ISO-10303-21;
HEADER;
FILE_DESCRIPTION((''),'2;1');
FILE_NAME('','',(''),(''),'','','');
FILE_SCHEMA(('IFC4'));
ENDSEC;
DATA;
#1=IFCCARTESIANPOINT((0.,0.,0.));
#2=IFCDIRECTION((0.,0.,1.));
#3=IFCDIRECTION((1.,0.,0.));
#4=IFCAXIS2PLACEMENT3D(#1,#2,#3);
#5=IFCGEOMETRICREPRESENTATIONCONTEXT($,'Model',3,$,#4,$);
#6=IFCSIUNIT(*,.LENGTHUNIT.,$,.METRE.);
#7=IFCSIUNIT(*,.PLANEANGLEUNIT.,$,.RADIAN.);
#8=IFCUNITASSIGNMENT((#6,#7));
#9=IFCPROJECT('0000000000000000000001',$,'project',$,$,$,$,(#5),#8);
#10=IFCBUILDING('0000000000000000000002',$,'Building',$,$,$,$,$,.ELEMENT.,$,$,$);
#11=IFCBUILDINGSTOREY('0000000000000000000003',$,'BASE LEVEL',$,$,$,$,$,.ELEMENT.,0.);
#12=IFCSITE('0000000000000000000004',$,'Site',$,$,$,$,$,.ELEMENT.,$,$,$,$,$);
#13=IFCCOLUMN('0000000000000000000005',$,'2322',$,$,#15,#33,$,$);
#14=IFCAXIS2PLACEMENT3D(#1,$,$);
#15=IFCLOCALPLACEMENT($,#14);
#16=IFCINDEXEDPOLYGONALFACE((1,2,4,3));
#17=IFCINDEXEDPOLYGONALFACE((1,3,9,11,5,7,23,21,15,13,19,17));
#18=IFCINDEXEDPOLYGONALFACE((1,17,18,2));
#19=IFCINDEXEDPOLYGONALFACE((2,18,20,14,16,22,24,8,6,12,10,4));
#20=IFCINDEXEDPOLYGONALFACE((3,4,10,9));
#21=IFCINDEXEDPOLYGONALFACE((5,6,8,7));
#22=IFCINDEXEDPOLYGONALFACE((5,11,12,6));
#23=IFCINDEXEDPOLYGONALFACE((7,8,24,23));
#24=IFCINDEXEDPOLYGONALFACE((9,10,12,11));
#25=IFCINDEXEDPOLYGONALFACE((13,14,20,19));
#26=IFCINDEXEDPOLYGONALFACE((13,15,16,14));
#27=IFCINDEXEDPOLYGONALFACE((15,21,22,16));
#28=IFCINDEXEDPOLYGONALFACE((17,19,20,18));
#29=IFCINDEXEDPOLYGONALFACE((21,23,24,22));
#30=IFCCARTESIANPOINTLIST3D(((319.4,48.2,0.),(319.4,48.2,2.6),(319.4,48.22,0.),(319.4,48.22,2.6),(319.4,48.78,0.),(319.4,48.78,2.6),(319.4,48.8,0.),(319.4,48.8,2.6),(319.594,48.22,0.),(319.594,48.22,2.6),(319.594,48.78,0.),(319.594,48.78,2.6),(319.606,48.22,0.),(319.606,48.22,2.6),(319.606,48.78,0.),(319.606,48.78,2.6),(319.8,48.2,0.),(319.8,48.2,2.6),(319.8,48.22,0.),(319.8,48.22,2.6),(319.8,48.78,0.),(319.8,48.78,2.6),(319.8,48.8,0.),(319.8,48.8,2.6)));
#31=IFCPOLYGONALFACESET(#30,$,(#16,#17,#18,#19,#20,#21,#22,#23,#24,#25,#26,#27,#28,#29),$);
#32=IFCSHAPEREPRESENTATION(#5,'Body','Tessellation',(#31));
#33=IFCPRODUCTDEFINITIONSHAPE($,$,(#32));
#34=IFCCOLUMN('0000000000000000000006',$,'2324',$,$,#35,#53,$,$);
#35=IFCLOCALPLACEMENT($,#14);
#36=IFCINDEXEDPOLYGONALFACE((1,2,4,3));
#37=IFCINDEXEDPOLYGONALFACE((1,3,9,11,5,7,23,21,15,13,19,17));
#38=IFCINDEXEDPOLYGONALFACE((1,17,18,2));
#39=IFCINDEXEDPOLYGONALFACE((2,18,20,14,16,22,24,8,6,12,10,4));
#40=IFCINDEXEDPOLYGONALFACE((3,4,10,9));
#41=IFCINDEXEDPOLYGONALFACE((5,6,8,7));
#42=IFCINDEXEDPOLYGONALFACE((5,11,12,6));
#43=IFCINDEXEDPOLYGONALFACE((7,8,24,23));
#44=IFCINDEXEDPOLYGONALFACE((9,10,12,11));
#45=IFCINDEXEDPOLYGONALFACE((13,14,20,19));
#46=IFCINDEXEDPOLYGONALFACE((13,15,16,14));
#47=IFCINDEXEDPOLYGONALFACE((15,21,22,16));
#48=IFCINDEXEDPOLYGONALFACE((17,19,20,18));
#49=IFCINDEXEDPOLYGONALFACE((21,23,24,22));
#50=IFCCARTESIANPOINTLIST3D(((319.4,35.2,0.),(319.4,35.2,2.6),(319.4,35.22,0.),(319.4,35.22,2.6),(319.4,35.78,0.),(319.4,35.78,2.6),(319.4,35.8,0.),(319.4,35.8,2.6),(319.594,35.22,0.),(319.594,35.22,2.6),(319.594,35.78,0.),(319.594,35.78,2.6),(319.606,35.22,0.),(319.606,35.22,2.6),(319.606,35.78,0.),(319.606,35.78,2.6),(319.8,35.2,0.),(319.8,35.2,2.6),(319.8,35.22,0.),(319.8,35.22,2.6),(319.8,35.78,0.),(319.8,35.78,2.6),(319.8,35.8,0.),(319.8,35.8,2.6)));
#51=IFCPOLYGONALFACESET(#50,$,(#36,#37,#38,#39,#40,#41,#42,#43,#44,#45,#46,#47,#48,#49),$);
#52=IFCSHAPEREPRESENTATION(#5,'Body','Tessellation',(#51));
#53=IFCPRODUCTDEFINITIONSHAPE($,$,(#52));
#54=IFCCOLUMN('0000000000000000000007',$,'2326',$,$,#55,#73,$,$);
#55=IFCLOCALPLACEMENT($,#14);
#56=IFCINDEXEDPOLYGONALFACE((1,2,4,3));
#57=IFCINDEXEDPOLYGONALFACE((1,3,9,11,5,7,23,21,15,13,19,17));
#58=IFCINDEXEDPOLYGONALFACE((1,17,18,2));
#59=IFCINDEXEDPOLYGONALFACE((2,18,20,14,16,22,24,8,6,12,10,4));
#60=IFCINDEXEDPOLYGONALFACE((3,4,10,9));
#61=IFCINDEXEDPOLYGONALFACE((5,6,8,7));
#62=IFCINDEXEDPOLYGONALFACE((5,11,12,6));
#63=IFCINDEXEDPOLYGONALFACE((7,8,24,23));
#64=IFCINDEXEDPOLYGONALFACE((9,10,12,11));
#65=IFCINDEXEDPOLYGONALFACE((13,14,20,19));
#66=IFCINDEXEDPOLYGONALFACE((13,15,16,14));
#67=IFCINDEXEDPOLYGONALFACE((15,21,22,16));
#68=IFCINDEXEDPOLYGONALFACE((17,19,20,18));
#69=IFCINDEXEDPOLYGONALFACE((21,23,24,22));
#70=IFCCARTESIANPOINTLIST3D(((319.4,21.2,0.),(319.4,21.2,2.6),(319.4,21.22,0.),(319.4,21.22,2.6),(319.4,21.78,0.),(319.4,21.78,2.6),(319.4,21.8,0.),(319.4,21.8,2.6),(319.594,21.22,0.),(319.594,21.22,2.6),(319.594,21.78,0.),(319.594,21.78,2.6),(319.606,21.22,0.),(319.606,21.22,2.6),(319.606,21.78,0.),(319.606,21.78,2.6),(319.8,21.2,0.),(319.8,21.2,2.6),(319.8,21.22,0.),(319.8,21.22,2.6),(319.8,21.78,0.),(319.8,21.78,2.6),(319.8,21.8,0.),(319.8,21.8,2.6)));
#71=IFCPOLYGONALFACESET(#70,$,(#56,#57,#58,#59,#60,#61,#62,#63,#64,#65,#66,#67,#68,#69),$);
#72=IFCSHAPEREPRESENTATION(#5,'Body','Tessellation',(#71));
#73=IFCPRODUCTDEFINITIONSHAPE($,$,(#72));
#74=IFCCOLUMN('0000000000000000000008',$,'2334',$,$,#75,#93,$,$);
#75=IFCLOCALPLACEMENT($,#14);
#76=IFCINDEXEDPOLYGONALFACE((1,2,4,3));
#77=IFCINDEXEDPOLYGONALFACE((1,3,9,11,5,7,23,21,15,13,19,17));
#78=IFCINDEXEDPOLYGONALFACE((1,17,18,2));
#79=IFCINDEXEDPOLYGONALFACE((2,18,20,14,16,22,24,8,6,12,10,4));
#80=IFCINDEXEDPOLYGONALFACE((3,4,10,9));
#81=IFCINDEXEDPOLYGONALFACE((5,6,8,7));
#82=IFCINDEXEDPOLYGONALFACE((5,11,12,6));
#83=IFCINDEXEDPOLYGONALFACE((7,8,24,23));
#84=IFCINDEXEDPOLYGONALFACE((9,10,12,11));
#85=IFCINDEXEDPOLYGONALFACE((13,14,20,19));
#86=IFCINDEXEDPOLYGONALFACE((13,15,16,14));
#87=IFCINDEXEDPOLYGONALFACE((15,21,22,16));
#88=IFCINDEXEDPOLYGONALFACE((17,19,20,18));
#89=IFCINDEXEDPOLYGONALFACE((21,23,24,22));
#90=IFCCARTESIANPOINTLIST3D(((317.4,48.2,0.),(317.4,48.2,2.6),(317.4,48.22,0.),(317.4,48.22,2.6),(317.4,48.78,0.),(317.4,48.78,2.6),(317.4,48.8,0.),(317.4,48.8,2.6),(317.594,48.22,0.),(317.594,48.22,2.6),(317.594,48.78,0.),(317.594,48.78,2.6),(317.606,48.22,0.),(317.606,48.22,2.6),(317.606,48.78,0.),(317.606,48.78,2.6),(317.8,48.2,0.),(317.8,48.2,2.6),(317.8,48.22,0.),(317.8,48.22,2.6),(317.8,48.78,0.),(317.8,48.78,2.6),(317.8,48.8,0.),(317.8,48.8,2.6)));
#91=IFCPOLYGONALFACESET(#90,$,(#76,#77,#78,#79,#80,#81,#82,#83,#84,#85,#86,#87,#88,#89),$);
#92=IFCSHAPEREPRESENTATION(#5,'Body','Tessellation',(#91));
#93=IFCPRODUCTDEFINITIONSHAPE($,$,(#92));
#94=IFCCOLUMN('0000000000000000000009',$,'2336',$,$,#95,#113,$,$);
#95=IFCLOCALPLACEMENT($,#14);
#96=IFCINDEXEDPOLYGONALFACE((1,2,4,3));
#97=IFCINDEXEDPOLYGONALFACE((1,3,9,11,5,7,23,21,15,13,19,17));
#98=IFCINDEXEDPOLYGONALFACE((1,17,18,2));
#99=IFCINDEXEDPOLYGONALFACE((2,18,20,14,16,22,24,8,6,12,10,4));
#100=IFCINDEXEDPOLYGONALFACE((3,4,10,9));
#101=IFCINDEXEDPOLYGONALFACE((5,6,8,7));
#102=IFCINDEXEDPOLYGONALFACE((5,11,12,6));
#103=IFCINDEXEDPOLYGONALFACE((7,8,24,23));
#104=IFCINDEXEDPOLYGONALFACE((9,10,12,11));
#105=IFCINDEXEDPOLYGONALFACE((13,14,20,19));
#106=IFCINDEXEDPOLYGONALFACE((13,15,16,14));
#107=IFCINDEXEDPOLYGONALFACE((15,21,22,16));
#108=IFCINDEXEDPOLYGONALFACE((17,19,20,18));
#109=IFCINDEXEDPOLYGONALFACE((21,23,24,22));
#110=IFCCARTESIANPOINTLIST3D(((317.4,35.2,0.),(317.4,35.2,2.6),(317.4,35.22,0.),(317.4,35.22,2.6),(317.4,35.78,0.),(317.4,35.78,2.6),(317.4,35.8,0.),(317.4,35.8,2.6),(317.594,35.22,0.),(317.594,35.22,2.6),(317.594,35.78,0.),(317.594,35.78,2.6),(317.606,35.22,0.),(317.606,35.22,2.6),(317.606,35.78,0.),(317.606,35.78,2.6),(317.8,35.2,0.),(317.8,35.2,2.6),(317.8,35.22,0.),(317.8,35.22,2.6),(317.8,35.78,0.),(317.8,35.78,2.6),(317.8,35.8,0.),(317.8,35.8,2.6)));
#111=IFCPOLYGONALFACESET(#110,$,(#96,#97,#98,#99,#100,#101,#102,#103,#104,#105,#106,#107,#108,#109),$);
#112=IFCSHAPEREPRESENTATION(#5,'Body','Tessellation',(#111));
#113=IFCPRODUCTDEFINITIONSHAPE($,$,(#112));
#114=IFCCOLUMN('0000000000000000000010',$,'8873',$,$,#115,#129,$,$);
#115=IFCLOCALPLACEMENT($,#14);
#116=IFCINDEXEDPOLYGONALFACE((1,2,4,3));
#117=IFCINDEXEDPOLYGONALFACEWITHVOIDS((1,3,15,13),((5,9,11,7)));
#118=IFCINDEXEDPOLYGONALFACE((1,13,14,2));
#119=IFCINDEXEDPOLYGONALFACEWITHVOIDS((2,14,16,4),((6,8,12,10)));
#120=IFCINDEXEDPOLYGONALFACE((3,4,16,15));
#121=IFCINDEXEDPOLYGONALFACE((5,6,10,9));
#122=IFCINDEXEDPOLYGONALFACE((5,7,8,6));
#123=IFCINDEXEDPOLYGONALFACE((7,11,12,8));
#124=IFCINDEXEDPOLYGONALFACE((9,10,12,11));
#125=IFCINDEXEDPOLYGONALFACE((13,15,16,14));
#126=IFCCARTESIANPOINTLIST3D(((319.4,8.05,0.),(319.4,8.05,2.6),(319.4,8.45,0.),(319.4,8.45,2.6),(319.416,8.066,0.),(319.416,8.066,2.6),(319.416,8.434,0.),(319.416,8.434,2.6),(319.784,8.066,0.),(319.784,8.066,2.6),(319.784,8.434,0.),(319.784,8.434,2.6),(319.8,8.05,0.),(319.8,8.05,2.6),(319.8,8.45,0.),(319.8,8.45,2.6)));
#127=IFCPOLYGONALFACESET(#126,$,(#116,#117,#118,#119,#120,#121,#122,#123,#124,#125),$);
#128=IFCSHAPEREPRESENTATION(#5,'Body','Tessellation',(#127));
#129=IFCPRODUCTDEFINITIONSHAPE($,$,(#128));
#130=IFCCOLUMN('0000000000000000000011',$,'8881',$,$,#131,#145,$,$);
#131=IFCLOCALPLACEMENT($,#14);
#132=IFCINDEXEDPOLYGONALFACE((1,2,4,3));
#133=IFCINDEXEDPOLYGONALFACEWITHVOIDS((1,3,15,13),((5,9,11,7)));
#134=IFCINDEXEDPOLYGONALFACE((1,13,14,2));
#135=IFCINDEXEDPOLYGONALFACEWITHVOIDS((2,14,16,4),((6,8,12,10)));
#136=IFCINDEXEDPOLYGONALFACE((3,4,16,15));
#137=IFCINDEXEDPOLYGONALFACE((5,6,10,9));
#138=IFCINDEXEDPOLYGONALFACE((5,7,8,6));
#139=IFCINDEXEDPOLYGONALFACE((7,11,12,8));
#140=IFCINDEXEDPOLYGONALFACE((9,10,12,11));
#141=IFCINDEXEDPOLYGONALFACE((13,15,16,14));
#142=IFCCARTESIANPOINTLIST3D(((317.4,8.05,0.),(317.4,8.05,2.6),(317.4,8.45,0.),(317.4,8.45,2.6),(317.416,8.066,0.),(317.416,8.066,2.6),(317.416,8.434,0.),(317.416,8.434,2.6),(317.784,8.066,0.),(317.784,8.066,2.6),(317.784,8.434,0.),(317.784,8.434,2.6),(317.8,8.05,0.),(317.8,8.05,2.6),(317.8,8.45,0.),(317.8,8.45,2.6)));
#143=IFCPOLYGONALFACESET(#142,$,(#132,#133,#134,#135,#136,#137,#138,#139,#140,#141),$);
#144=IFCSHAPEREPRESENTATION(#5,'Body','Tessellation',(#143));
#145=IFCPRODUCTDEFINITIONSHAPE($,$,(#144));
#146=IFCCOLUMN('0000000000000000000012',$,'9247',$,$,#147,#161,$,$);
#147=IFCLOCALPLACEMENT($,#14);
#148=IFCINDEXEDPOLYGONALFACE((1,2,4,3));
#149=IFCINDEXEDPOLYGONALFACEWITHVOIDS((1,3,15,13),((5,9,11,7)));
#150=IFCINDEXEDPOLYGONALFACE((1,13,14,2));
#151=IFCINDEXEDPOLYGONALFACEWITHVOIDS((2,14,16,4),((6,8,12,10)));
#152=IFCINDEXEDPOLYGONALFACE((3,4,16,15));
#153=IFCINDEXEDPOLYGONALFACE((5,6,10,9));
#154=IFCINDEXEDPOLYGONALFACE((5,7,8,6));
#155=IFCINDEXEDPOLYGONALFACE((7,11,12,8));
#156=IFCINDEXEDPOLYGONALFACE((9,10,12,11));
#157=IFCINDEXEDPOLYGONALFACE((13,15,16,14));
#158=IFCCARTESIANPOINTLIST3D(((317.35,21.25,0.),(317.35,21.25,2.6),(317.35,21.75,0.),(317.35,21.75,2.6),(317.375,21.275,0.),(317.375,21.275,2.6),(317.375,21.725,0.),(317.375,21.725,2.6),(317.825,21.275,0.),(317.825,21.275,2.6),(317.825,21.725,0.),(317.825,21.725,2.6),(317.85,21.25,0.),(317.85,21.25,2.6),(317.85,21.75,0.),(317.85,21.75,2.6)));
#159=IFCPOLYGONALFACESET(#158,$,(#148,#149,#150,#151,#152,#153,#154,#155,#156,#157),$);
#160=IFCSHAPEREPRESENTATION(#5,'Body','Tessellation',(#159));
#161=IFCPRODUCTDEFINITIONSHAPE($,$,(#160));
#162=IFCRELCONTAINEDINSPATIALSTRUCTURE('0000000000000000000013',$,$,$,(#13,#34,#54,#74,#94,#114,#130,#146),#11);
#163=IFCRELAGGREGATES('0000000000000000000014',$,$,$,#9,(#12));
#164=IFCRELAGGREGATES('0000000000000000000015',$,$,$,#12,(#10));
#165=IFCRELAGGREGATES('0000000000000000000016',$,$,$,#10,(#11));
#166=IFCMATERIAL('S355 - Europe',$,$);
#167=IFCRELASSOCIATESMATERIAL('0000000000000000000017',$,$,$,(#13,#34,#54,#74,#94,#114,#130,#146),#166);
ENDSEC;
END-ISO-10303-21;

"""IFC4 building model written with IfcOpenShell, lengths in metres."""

from ifc_helpers import new_model, si_unit, frame, origin_with_axes, origin_2d_with_axis, place, context, project, spatial, hollow_rectangle, i_section, extrude, material, material_profile, profile_set, profile_usage, element, save


model = new_model("IFC4")

# Units and contexts
model_context = context("Model", 3, world=origin_with_axes())
ifc_project = project(units=[si_unit("LENGTHUNIT", "METRE"), si_unit("PLANEANGLEUNIT", "RADIAN")], contexts=[model_context])

# Site, building, storey
site = spatial("IfcSite", under=ifc_project, Name="Site", CompositionType="ELEMENT")
building = spatial("IfcBuilding", under=site, Name="Building", CompositionType="ELEMENT")
storey = spatial("IfcBuildingStorey", under=building, Name="BASE LEVEL", CompositionType="ELEMENT", Elevation=0.0)

# Columns
ifc_material = material(Name="S355 - Europe")
ifc_material_profile_1 = material_profile(ifc_material, i_section(OverallWidth=0.4, OverallDepth=0.6, WebThickness=0.012, FlangeThickness=0.02, at=origin_2d_with_axis()))
ifc_profile_set_1 = profile_set([ifc_material_profile_1])
ifc_profile_usage_1 = profile_usage(ifc_profile_set_1, cardinal=10)
column_1_placement = place(None, frame((319.6, 48.5, 0.0), z_axis=(0.0, 0.0, 1.0), x_axis=(1.0, 0.0, 0.0)))
element("IfcColumn", 1, at=column_1_placement, inside=storey, material=ifc_profile_usage_1, Name="2322", context=model_context, shape_type="SweptSolid", body=[
    extrude(i_section(OverallWidth=0.4, OverallDepth=0.6, WebThickness=0.012, FlangeThickness=0.02, at=origin_2d_with_axis()), origin_with_axes(), (0.0, 0.0, 1.0), 2.6),
])
ifc_material_profile_2 = material_profile(ifc_material, i_section(OverallWidth=0.4, OverallDepth=0.6, WebThickness=0.012, FlangeThickness=0.02, at=origin_2d_with_axis()))
ifc_profile_set_2 = profile_set([ifc_material_profile_2])
ifc_profile_usage_2 = profile_usage(ifc_profile_set_2, cardinal=10)
column_2_placement = place(None, frame((319.6, 35.5, 0.0), z_axis=(0.0, 0.0, 1.0), x_axis=(1.0, 0.0, 0.0)))
element("IfcColumn", 2, at=column_2_placement, inside=storey, material=ifc_profile_usage_2, Name="2324", context=model_context, shape_type="SweptSolid", body=[
    extrude(i_section(OverallWidth=0.4, OverallDepth=0.6, WebThickness=0.012, FlangeThickness=0.02, at=origin_2d_with_axis()), origin_with_axes(), (0.0, 0.0, 1.0), 2.6),
])
ifc_material_profile_3 = material_profile(ifc_material, i_section(OverallWidth=0.4, OverallDepth=0.6, WebThickness=0.012, FlangeThickness=0.02, at=origin_2d_with_axis()))
ifc_profile_set_3 = profile_set([ifc_material_profile_3])
ifc_profile_usage_3 = profile_usage(ifc_profile_set_3, cardinal=10)
column_3_placement = place(None, frame((319.6, 21.5, 0.0), z_axis=(0.0, 0.0, 1.0), x_axis=(1.0, 0.0, 0.0)))
element("IfcColumn", 3, at=column_3_placement, inside=storey, material=ifc_profile_usage_3, Name="2326", context=model_context, shape_type="SweptSolid", body=[
    extrude(i_section(OverallWidth=0.4, OverallDepth=0.6, WebThickness=0.012, FlangeThickness=0.02, at=origin_2d_with_axis()), origin_with_axes(), (0.0, 0.0, 1.0), 2.6),
])
ifc_material_profile_4 = material_profile(ifc_material, i_section(OverallWidth=0.4, OverallDepth=0.6, WebThickness=0.012, FlangeThickness=0.02, at=origin_2d_with_axis()))
ifc_profile_set_4 = profile_set([ifc_material_profile_4])
ifc_profile_usage_4 = profile_usage(ifc_profile_set_4, cardinal=10)
column_4_placement = place(None, frame((317.6, 48.5, 0.0), z_axis=(0.0, 0.0, 1.0), x_axis=(1.0, 0.0, 0.0)))
element("IfcColumn", 4, at=column_4_placement, inside=storey, material=ifc_profile_usage_4, Name="2334", context=model_context, shape_type="SweptSolid", body=[
    extrude(i_section(OverallWidth=0.4, OverallDepth=0.6, WebThickness=0.012, FlangeThickness=0.02, at=origin_2d_with_axis()), origin_with_axes(), (0.0, 0.0, 1.0), 2.6),
])
ifc_material_profile_5 = material_profile(ifc_material, i_section(OverallWidth=0.4, OverallDepth=0.6, WebThickness=0.012, FlangeThickness=0.02, at=origin_2d_with_axis()))
ifc_profile_set_5 = profile_set([ifc_material_profile_5])
ifc_profile_usage_5 = profile_usage(ifc_profile_set_5, cardinal=10)
column_5_placement = place(None, frame((317.6, 35.5, 0.0), z_axis=(0.0, 0.0, 1.0), x_axis=(1.0, 0.0, 0.0)))
element("IfcColumn", 5, at=column_5_placement, inside=storey, material=ifc_profile_usage_5, Name="2336", context=model_context, shape_type="SweptSolid", body=[
    extrude(i_section(OverallWidth=0.4, OverallDepth=0.6, WebThickness=0.012, FlangeThickness=0.02, at=origin_2d_with_axis()), origin_with_axes(), (0.0, 0.0, 1.0), 2.6),
])
ifc_material_profile_6 = material_profile(ifc_material, hollow_rectangle(XDim=0.4, YDim=0.4, WallThickness=0.016, at=origin_2d_with_axis()))
ifc_profile_set_6 = profile_set([ifc_material_profile_6])
ifc_profile_usage_6 = profile_usage(ifc_profile_set_6, cardinal=10)
column_6_placement = place(None, frame((319.6, 8.25, 0.0), z_axis=(0.0, 0.0, 1.0), x_axis=(0.0, -1.0, 0.0)))
element("IfcColumn", 6, at=column_6_placement, inside=storey, material=ifc_profile_usage_6, Name="8873", context=model_context, shape_type="SweptSolid", body=[
    extrude(hollow_rectangle(XDim=0.4, YDim=0.4, WallThickness=0.016, at=origin_2d_with_axis()), origin_with_axes(), (0.0, 0.0, 1.0), 2.6),
])
ifc_material_profile_7 = material_profile(ifc_material, hollow_rectangle(XDim=0.4, YDim=0.4, WallThickness=0.016, at=origin_2d_with_axis()))
ifc_profile_set_7 = profile_set([ifc_material_profile_7])
ifc_profile_usage_7 = profile_usage(ifc_profile_set_7, cardinal=10)
column_7_placement = place(None, frame((317.6, 8.25, 0.0), z_axis=(0.0, 0.0, 1.0), x_axis=(0.0, -1.0, 0.0)))
element("IfcColumn", 7, at=column_7_placement, inside=storey, material=ifc_profile_usage_7, Name="8881", context=model_context, shape_type="SweptSolid", body=[
    extrude(hollow_rectangle(XDim=0.4, YDim=0.4, WallThickness=0.016, at=origin_2d_with_axis()), origin_with_axes(), (0.0, 0.0, 1.0), 2.6),
])
ifc_material_profile_8 = material_profile(ifc_material, hollow_rectangle(XDim=0.5, YDim=0.5, WallThickness=0.025, at=origin_2d_with_axis()))
ifc_profile_set_8 = profile_set([ifc_material_profile_8])
ifc_profile_usage_8 = profile_usage(ifc_profile_set_8, cardinal=10)
column_8_placement = place(None, frame((317.6, 21.5, 0.0), z_axis=(0.0, 0.0, 1.0), x_axis=(1.0, 0.0, 0.0)))
element("IfcColumn", 8, at=column_8_placement, inside=storey, material=ifc_profile_usage_8, Name="9247", context=model_context, shape_type="SweptSolid", body=[
    extrude(hollow_rectangle(XDim=0.5, YDim=0.5, WallThickness=0.025, at=origin_2d_with_axis()), origin_with_axes(), (0.0, 0.0, 1.0), 2.6),
])

save(model, "model.ifc")
